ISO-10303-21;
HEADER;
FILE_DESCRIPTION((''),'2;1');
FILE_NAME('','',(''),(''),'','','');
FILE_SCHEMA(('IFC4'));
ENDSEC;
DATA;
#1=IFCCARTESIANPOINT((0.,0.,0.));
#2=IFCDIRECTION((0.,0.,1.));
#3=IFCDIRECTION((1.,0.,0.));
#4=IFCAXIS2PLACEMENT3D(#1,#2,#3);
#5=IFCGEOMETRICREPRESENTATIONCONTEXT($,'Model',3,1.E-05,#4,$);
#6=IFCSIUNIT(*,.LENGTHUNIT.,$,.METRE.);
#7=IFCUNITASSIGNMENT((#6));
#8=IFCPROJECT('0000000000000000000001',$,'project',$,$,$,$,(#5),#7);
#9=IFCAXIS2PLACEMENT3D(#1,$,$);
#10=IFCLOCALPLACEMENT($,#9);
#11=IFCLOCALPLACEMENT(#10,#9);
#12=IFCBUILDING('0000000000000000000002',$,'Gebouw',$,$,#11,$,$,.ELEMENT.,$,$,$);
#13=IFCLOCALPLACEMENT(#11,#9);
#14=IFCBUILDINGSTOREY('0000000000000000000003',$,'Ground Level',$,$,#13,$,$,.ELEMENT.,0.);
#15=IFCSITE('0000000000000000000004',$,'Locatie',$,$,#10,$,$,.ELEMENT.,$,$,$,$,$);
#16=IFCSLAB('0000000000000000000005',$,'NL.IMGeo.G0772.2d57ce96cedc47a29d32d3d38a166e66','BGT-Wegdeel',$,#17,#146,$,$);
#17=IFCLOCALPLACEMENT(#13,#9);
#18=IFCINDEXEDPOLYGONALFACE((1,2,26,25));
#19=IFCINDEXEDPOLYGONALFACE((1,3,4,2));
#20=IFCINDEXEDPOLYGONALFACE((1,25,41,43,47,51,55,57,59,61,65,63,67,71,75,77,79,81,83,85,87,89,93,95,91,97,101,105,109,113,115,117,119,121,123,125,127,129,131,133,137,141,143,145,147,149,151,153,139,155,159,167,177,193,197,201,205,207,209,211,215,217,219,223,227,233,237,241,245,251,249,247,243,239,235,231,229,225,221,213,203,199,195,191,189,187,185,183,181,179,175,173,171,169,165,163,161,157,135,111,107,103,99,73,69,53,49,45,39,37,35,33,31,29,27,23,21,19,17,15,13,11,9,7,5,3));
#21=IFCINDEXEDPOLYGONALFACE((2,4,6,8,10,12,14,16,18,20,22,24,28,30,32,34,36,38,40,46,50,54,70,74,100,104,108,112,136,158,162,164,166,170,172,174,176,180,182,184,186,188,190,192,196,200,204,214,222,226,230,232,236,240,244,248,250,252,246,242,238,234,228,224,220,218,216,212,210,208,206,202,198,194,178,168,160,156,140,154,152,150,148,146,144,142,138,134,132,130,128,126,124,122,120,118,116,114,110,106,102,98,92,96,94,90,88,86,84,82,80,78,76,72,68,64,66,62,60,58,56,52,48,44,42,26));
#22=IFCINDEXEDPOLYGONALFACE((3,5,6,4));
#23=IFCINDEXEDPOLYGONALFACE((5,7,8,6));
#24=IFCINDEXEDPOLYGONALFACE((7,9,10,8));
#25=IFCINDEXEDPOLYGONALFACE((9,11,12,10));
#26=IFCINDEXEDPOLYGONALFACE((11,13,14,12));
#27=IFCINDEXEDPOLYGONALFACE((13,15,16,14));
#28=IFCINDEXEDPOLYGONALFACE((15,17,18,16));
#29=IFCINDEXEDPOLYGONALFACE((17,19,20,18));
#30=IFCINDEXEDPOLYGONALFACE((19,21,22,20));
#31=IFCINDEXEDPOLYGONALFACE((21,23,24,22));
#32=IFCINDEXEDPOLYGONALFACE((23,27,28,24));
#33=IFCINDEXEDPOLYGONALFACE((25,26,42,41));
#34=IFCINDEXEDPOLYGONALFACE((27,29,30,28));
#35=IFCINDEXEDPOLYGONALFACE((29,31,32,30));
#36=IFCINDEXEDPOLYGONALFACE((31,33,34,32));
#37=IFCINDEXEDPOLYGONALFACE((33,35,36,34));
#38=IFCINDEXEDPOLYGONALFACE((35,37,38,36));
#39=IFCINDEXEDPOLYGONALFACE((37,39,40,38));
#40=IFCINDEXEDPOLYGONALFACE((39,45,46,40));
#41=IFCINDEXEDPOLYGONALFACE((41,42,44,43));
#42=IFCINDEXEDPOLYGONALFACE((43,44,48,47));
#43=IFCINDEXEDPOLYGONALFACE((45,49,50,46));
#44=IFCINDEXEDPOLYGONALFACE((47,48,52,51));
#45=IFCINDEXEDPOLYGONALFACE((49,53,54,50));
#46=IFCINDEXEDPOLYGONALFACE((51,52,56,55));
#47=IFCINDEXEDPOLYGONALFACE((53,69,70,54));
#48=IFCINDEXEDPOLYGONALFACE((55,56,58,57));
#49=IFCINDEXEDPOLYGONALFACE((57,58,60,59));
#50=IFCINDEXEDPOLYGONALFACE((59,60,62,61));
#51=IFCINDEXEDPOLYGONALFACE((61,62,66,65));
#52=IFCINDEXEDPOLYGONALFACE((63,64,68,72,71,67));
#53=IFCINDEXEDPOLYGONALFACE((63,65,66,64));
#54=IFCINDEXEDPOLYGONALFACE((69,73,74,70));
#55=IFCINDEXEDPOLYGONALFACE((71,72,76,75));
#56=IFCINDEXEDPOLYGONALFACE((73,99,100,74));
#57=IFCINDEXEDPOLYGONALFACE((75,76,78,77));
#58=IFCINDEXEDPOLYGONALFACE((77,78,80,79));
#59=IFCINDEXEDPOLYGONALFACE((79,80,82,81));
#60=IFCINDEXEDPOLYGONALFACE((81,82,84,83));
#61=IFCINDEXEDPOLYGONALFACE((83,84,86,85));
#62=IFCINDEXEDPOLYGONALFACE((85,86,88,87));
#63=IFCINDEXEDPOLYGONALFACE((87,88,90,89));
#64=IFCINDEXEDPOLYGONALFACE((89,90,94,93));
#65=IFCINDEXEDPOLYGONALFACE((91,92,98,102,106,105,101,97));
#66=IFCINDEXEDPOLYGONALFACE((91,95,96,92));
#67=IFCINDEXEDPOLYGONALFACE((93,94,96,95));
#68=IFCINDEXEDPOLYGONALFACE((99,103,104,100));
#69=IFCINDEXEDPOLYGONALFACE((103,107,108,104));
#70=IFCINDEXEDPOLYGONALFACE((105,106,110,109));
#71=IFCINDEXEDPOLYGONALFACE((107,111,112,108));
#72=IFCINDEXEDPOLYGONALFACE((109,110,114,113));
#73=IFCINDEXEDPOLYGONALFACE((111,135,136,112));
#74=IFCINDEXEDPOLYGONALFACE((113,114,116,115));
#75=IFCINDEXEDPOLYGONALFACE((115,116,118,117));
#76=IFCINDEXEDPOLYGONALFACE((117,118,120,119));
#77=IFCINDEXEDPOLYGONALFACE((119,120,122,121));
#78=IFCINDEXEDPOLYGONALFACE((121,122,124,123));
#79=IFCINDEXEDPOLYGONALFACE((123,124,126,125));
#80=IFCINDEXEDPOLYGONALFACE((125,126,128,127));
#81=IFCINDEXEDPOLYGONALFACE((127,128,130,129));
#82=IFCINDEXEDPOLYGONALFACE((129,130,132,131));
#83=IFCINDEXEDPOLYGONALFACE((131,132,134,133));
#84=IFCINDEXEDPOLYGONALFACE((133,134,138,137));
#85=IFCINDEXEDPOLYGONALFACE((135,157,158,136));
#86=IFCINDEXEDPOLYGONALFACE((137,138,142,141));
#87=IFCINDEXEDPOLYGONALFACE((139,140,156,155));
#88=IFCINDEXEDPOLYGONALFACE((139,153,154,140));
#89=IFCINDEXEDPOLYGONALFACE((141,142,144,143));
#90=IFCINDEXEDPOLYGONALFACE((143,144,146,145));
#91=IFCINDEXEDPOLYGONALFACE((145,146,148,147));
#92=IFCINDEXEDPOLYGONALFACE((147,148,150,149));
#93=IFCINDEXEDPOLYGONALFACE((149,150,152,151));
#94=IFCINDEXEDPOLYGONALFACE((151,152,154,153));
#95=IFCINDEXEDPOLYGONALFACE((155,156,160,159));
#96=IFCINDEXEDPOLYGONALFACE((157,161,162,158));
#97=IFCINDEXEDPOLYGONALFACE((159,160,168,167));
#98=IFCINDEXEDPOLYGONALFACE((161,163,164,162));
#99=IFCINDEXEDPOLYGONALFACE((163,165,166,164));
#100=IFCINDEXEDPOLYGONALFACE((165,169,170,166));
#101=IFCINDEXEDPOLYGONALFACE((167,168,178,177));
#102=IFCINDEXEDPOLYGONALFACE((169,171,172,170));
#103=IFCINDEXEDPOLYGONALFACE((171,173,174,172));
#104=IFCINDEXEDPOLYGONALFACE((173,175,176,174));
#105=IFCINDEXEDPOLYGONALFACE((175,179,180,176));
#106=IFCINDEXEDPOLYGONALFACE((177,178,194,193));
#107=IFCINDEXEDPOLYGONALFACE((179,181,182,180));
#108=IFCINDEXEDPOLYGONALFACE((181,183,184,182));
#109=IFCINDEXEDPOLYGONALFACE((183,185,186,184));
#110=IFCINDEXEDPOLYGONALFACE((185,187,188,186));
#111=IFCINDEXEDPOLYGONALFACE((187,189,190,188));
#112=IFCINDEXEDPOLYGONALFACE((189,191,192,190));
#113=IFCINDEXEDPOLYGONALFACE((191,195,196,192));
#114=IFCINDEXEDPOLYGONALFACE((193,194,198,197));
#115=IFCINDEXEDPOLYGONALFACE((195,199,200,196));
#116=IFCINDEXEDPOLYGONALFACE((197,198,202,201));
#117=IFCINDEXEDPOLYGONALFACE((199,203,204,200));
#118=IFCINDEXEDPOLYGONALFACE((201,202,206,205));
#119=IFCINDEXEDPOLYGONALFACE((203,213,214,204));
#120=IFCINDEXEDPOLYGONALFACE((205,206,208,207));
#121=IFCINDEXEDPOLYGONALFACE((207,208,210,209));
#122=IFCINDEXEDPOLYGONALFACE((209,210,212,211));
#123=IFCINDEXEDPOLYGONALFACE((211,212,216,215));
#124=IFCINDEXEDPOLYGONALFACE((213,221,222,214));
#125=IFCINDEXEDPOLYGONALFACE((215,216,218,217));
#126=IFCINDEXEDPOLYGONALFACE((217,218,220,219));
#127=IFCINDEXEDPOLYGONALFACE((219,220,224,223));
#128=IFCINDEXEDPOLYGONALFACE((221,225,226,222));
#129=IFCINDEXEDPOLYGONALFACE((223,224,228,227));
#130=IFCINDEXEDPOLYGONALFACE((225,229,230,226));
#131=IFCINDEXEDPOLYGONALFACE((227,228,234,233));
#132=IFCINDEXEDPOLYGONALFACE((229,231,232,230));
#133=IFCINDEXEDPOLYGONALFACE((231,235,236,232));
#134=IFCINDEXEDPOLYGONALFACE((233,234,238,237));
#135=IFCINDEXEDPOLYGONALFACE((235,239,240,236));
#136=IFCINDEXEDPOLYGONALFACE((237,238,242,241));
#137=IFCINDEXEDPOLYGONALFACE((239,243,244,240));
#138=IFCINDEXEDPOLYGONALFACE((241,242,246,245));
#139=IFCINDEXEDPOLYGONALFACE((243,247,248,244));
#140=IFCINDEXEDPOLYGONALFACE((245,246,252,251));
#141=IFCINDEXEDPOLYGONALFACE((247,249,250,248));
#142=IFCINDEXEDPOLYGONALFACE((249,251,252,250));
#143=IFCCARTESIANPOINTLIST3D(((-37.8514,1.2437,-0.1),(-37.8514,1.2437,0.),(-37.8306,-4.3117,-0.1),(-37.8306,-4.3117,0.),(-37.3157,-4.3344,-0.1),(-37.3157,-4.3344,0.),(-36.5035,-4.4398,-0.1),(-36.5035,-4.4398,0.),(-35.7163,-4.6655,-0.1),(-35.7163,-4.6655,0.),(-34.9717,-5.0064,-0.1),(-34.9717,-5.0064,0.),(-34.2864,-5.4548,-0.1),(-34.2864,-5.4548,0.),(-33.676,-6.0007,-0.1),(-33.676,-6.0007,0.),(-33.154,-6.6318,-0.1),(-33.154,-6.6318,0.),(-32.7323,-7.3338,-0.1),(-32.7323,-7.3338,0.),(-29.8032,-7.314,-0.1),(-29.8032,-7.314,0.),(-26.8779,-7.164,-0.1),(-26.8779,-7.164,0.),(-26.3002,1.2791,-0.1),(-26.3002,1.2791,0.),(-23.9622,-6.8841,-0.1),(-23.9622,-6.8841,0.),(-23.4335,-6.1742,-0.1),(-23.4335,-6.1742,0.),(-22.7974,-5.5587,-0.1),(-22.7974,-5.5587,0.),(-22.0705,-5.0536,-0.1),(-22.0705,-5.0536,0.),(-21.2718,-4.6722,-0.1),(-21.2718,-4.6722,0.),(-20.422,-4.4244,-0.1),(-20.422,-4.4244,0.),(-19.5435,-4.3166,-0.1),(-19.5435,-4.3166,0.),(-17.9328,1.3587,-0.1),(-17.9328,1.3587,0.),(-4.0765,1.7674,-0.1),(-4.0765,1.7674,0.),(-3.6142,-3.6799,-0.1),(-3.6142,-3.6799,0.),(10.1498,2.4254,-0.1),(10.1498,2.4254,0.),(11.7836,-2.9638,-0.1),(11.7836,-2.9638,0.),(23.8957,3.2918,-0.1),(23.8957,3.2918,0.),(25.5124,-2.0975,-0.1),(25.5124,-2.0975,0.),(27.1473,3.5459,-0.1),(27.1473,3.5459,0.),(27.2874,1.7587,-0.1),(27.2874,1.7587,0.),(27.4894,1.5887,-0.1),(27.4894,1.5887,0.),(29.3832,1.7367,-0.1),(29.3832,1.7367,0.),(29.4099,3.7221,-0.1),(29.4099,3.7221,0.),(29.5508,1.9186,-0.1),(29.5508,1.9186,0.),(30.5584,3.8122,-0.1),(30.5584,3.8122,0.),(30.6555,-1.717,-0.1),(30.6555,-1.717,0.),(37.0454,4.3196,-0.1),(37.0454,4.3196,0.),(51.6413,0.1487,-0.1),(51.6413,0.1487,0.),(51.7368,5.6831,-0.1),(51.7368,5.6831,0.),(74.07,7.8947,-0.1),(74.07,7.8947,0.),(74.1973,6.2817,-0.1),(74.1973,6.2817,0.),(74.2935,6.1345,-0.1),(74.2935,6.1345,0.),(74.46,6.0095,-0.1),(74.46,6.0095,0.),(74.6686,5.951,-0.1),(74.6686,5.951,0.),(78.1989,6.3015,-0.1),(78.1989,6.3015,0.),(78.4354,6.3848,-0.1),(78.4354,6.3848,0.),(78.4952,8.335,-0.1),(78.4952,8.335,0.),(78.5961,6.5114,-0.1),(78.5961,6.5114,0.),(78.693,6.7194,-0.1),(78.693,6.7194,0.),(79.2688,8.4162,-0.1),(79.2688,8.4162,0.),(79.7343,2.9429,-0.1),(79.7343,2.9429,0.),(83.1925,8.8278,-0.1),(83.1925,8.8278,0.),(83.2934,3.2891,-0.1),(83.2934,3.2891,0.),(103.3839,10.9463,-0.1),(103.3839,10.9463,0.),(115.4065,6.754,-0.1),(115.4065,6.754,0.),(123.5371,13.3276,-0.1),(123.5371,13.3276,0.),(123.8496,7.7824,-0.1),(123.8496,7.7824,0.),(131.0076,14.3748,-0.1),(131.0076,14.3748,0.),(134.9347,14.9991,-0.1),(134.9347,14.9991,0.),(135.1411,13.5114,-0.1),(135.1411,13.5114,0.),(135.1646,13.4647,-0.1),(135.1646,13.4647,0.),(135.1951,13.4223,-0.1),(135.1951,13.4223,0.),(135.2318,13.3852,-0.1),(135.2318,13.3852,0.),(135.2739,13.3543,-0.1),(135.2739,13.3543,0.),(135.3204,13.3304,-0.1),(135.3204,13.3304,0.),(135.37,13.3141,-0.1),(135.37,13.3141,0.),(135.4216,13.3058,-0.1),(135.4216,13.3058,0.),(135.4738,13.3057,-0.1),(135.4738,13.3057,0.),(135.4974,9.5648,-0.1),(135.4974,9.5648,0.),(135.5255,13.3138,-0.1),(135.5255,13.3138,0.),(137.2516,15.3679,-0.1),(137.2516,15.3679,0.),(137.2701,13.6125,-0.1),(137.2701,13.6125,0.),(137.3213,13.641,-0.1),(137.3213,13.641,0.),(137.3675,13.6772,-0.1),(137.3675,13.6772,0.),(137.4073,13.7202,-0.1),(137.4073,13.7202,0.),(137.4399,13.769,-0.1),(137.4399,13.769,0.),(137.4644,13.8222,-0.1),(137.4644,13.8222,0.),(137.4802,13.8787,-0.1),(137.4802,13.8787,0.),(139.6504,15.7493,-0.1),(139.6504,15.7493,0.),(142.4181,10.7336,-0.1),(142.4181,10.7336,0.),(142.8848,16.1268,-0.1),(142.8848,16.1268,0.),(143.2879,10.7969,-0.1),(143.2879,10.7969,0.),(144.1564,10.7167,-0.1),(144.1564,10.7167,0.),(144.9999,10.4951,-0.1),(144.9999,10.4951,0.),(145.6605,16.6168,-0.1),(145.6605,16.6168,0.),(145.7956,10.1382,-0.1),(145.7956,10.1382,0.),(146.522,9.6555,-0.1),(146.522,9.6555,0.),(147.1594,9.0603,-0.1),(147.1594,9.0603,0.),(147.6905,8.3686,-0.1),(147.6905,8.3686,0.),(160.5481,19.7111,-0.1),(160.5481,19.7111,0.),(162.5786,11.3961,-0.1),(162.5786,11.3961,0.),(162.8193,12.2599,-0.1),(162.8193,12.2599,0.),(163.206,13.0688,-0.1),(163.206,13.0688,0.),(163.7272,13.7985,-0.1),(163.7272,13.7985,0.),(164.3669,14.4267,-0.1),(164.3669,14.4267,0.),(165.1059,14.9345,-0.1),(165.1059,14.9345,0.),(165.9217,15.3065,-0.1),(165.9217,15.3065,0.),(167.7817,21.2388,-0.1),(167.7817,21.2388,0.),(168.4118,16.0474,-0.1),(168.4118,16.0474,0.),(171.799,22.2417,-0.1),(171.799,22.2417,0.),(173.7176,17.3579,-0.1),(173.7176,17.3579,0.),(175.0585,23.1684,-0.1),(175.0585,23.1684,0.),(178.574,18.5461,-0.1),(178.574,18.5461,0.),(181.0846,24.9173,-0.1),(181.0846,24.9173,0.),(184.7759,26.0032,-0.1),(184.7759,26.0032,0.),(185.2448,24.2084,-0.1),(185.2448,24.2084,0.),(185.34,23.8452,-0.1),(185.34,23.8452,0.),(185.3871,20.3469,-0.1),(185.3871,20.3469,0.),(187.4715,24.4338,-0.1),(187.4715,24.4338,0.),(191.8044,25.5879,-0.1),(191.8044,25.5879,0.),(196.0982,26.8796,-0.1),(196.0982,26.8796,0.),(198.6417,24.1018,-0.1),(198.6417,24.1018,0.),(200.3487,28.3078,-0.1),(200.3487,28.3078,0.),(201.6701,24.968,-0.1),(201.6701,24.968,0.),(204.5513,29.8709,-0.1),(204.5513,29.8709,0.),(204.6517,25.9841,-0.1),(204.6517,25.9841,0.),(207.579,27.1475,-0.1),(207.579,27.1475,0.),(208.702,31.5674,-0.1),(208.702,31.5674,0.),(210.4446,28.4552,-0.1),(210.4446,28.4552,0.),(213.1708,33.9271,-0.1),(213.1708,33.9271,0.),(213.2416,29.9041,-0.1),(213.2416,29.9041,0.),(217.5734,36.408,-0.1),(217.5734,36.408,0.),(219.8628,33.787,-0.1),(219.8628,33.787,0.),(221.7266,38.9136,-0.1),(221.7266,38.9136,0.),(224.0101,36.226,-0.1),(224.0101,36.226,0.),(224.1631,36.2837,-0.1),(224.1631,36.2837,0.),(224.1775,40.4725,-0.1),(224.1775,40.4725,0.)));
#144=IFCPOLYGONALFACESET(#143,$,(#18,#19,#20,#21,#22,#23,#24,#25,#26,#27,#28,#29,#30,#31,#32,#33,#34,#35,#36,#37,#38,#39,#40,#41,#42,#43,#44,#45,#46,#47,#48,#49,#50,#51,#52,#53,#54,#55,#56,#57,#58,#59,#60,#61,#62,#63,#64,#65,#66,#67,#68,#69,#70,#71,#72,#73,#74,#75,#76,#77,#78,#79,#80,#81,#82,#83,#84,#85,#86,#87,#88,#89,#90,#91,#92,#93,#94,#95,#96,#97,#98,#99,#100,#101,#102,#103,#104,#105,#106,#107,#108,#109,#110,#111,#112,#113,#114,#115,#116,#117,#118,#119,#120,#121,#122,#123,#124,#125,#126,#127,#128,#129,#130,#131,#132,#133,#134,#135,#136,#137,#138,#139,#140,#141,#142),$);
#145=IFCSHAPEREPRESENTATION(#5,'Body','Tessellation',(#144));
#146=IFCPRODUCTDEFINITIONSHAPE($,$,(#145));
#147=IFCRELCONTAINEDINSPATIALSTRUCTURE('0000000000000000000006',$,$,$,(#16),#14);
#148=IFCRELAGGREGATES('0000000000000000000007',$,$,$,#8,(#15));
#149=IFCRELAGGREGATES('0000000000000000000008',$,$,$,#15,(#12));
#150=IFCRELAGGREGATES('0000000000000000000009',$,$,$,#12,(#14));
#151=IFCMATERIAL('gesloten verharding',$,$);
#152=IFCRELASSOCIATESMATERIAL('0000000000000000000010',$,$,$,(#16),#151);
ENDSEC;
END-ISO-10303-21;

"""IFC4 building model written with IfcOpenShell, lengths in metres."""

from ifc_helpers import new_model, si_unit, frame, origin, origin_with_axes, place, context, project, spatial, polyline, outline, extrude, material, element, save


model = new_model("IFC4")

# Units and contexts
model_context = context("Model", 3, precision=1e-05, world=origin_with_axes())
ifc_project = project(units=[si_unit("LENGTHUNIT", "METRE")], contexts=[model_context])

# Site, building, storey
site_placement = place(None, origin())
site = spatial("IfcSite", under=ifc_project, at=site_placement, Name="Locatie", CompositionType="ELEMENT")
building_placement = place(site_placement, origin())
building = spatial("IfcBuilding", under=site, at=building_placement, Name="Gebouw", CompositionType="ELEMENT")
storey_placement = place(building_placement, origin())
storey = spatial("IfcBuildingStorey", under=building, at=storey_placement, Name="Ground Level", CompositionType="ELEMENT", Elevation=0.0)

# Slab
ifc_material_1 = material(Name="gesloten verharding")
slab_1_placement = place(storey_placement, origin())
element("IfcSlab", 1, at=slab_1_placement, inside=storey, material=ifc_material_1, Name="NL.IMGeo.G0772.2d57ce96cedc47a29d32d3d38a166e66", Description="BGT-Wegdeel", context=model_context, shape_type="SweptSolid", body=[
    extrude(outline(polyline([(37.0454, 4.3196), (51.7368, 5.6831), (74.07, 7.8947), (74.1973, 6.2817), (74.2935, 6.1345), (74.46, 6.0095), (74.6686, 5.951), (78.1989, 6.3015), (78.4354, 6.3848), (78.5961, 6.5114), (78.693, 6.7194), (78.4952, 8.335), (79.2688, 8.4162), (83.1925, 8.8278), (103.3839, 10.9463), (123.5371, 13.3276), (131.0076, 14.3748), (134.9347, 14.9991), (135.1411, 13.5114), (135.1646, 13.4647), (135.1951, 13.4223), (135.2318, 13.3852), (135.2739, 13.3543), (135.3204, 13.3304), (135.37, 13.3141), (135.4216, 13.3058), (135.4738, 13.3057), (135.5255, 13.3138), (137.2701, 13.6125), (137.3213, 13.641), (137.3675, 13.6772), (137.4073, 13.7202), (137.4399, 13.769), (137.4644, 13.8222), (137.4802, 13.8787), (137.2516, 15.3679), (139.6504, 15.7493), (142.8848, 16.1268), (145.6605, 16.6168), (160.5481, 19.7111), (167.7817, 21.2388), (171.799, 22.2417), (175.0585, 23.1684), (181.0846, 24.9173), (184.7759, 26.0032), (185.2448, 24.2084), (185.34, 23.8452), (187.4715, 24.4338), (191.8044, 25.5879), (196.0982, 26.8796), (200.3487, 28.3078), (204.5513, 29.8709), (208.702, 31.5674), (213.1708, 33.9271), (217.5734, 36.408), (221.7266, 38.9136), (224.1775, 40.4725), (224.1631, 36.2837), (224.0101, 36.226), (219.8628, 33.787), (213.2416, 29.9041), (210.4446, 28.4552), (207.579, 27.1475), (204.6517, 25.9841), (201.6701, 24.968), (198.6417, 24.1018), (185.3871, 20.3469), (178.574, 18.5461), (173.7176, 17.3579), (168.4118, 16.0474), (165.9217, 15.3065), (165.1059, 14.9345), (164.3669, 14.4267), (163.7272, 13.7985), (163.206, 13.0688), (162.8193, 12.2599), (162.5786, 11.3961), (147.6905, 8.3686), (147.1594, 9.0603), (146.522, 9.6555), (145.7956, 10.1382), (144.9999, 10.4951), (144.1564, 10.7167), (143.2879, 10.7969), (142.4181, 10.7336), (135.4974, 9.5648), (123.8496, 7.7824), (115.4065, 6.754), (83.2934, 3.2891), (79.7343, 2.9429), (51.6413, 0.1487), (30.6555, -1.717), (25.5124, -2.0975), (11.7836, -2.9638), (-3.6142, -3.6799), (-19.5435, -4.3166), (-20.422, -4.4244), (-21.2718, -4.6722), (-22.0705, -5.0536), (-22.7974, -5.5587), (-23.4335, -6.1742), (-23.9622, -6.8841), (-26.8779, -7.164), (-29.8032, -7.314), (-32.7323, -7.3338), (-33.154, -6.6318), (-33.676, -6.0007), (-34.2864, -5.4548), (-34.9717, -5.0064), (-35.7163, -4.6655), (-36.5035, -4.4398), (-37.3157, -4.3344), (-37.8306, -4.3117), (-37.8514, 1.2437), (-26.3002, 1.2791), (-17.9328, 1.3587), (-4.0765, 1.7674), (10.1498, 2.4254), (23.8957, 3.2918), (27.1473, 3.5459), (27.2874, 1.7587), (27.4894, 1.5887), (29.3832, 1.7367), (29.5508, 1.9186), (29.4099, 3.7221), (30.5584, 3.8122), (37.0454, 4.3196)])), frame((0.0, 0.0, -0.1), z_axis=(0.0, 0.0, 1.0), x_axis=(1.0, 0.0, 0.0)), (0.0, 0.0, 1.0), 0.1),
])

save(model, "model.ifc")
